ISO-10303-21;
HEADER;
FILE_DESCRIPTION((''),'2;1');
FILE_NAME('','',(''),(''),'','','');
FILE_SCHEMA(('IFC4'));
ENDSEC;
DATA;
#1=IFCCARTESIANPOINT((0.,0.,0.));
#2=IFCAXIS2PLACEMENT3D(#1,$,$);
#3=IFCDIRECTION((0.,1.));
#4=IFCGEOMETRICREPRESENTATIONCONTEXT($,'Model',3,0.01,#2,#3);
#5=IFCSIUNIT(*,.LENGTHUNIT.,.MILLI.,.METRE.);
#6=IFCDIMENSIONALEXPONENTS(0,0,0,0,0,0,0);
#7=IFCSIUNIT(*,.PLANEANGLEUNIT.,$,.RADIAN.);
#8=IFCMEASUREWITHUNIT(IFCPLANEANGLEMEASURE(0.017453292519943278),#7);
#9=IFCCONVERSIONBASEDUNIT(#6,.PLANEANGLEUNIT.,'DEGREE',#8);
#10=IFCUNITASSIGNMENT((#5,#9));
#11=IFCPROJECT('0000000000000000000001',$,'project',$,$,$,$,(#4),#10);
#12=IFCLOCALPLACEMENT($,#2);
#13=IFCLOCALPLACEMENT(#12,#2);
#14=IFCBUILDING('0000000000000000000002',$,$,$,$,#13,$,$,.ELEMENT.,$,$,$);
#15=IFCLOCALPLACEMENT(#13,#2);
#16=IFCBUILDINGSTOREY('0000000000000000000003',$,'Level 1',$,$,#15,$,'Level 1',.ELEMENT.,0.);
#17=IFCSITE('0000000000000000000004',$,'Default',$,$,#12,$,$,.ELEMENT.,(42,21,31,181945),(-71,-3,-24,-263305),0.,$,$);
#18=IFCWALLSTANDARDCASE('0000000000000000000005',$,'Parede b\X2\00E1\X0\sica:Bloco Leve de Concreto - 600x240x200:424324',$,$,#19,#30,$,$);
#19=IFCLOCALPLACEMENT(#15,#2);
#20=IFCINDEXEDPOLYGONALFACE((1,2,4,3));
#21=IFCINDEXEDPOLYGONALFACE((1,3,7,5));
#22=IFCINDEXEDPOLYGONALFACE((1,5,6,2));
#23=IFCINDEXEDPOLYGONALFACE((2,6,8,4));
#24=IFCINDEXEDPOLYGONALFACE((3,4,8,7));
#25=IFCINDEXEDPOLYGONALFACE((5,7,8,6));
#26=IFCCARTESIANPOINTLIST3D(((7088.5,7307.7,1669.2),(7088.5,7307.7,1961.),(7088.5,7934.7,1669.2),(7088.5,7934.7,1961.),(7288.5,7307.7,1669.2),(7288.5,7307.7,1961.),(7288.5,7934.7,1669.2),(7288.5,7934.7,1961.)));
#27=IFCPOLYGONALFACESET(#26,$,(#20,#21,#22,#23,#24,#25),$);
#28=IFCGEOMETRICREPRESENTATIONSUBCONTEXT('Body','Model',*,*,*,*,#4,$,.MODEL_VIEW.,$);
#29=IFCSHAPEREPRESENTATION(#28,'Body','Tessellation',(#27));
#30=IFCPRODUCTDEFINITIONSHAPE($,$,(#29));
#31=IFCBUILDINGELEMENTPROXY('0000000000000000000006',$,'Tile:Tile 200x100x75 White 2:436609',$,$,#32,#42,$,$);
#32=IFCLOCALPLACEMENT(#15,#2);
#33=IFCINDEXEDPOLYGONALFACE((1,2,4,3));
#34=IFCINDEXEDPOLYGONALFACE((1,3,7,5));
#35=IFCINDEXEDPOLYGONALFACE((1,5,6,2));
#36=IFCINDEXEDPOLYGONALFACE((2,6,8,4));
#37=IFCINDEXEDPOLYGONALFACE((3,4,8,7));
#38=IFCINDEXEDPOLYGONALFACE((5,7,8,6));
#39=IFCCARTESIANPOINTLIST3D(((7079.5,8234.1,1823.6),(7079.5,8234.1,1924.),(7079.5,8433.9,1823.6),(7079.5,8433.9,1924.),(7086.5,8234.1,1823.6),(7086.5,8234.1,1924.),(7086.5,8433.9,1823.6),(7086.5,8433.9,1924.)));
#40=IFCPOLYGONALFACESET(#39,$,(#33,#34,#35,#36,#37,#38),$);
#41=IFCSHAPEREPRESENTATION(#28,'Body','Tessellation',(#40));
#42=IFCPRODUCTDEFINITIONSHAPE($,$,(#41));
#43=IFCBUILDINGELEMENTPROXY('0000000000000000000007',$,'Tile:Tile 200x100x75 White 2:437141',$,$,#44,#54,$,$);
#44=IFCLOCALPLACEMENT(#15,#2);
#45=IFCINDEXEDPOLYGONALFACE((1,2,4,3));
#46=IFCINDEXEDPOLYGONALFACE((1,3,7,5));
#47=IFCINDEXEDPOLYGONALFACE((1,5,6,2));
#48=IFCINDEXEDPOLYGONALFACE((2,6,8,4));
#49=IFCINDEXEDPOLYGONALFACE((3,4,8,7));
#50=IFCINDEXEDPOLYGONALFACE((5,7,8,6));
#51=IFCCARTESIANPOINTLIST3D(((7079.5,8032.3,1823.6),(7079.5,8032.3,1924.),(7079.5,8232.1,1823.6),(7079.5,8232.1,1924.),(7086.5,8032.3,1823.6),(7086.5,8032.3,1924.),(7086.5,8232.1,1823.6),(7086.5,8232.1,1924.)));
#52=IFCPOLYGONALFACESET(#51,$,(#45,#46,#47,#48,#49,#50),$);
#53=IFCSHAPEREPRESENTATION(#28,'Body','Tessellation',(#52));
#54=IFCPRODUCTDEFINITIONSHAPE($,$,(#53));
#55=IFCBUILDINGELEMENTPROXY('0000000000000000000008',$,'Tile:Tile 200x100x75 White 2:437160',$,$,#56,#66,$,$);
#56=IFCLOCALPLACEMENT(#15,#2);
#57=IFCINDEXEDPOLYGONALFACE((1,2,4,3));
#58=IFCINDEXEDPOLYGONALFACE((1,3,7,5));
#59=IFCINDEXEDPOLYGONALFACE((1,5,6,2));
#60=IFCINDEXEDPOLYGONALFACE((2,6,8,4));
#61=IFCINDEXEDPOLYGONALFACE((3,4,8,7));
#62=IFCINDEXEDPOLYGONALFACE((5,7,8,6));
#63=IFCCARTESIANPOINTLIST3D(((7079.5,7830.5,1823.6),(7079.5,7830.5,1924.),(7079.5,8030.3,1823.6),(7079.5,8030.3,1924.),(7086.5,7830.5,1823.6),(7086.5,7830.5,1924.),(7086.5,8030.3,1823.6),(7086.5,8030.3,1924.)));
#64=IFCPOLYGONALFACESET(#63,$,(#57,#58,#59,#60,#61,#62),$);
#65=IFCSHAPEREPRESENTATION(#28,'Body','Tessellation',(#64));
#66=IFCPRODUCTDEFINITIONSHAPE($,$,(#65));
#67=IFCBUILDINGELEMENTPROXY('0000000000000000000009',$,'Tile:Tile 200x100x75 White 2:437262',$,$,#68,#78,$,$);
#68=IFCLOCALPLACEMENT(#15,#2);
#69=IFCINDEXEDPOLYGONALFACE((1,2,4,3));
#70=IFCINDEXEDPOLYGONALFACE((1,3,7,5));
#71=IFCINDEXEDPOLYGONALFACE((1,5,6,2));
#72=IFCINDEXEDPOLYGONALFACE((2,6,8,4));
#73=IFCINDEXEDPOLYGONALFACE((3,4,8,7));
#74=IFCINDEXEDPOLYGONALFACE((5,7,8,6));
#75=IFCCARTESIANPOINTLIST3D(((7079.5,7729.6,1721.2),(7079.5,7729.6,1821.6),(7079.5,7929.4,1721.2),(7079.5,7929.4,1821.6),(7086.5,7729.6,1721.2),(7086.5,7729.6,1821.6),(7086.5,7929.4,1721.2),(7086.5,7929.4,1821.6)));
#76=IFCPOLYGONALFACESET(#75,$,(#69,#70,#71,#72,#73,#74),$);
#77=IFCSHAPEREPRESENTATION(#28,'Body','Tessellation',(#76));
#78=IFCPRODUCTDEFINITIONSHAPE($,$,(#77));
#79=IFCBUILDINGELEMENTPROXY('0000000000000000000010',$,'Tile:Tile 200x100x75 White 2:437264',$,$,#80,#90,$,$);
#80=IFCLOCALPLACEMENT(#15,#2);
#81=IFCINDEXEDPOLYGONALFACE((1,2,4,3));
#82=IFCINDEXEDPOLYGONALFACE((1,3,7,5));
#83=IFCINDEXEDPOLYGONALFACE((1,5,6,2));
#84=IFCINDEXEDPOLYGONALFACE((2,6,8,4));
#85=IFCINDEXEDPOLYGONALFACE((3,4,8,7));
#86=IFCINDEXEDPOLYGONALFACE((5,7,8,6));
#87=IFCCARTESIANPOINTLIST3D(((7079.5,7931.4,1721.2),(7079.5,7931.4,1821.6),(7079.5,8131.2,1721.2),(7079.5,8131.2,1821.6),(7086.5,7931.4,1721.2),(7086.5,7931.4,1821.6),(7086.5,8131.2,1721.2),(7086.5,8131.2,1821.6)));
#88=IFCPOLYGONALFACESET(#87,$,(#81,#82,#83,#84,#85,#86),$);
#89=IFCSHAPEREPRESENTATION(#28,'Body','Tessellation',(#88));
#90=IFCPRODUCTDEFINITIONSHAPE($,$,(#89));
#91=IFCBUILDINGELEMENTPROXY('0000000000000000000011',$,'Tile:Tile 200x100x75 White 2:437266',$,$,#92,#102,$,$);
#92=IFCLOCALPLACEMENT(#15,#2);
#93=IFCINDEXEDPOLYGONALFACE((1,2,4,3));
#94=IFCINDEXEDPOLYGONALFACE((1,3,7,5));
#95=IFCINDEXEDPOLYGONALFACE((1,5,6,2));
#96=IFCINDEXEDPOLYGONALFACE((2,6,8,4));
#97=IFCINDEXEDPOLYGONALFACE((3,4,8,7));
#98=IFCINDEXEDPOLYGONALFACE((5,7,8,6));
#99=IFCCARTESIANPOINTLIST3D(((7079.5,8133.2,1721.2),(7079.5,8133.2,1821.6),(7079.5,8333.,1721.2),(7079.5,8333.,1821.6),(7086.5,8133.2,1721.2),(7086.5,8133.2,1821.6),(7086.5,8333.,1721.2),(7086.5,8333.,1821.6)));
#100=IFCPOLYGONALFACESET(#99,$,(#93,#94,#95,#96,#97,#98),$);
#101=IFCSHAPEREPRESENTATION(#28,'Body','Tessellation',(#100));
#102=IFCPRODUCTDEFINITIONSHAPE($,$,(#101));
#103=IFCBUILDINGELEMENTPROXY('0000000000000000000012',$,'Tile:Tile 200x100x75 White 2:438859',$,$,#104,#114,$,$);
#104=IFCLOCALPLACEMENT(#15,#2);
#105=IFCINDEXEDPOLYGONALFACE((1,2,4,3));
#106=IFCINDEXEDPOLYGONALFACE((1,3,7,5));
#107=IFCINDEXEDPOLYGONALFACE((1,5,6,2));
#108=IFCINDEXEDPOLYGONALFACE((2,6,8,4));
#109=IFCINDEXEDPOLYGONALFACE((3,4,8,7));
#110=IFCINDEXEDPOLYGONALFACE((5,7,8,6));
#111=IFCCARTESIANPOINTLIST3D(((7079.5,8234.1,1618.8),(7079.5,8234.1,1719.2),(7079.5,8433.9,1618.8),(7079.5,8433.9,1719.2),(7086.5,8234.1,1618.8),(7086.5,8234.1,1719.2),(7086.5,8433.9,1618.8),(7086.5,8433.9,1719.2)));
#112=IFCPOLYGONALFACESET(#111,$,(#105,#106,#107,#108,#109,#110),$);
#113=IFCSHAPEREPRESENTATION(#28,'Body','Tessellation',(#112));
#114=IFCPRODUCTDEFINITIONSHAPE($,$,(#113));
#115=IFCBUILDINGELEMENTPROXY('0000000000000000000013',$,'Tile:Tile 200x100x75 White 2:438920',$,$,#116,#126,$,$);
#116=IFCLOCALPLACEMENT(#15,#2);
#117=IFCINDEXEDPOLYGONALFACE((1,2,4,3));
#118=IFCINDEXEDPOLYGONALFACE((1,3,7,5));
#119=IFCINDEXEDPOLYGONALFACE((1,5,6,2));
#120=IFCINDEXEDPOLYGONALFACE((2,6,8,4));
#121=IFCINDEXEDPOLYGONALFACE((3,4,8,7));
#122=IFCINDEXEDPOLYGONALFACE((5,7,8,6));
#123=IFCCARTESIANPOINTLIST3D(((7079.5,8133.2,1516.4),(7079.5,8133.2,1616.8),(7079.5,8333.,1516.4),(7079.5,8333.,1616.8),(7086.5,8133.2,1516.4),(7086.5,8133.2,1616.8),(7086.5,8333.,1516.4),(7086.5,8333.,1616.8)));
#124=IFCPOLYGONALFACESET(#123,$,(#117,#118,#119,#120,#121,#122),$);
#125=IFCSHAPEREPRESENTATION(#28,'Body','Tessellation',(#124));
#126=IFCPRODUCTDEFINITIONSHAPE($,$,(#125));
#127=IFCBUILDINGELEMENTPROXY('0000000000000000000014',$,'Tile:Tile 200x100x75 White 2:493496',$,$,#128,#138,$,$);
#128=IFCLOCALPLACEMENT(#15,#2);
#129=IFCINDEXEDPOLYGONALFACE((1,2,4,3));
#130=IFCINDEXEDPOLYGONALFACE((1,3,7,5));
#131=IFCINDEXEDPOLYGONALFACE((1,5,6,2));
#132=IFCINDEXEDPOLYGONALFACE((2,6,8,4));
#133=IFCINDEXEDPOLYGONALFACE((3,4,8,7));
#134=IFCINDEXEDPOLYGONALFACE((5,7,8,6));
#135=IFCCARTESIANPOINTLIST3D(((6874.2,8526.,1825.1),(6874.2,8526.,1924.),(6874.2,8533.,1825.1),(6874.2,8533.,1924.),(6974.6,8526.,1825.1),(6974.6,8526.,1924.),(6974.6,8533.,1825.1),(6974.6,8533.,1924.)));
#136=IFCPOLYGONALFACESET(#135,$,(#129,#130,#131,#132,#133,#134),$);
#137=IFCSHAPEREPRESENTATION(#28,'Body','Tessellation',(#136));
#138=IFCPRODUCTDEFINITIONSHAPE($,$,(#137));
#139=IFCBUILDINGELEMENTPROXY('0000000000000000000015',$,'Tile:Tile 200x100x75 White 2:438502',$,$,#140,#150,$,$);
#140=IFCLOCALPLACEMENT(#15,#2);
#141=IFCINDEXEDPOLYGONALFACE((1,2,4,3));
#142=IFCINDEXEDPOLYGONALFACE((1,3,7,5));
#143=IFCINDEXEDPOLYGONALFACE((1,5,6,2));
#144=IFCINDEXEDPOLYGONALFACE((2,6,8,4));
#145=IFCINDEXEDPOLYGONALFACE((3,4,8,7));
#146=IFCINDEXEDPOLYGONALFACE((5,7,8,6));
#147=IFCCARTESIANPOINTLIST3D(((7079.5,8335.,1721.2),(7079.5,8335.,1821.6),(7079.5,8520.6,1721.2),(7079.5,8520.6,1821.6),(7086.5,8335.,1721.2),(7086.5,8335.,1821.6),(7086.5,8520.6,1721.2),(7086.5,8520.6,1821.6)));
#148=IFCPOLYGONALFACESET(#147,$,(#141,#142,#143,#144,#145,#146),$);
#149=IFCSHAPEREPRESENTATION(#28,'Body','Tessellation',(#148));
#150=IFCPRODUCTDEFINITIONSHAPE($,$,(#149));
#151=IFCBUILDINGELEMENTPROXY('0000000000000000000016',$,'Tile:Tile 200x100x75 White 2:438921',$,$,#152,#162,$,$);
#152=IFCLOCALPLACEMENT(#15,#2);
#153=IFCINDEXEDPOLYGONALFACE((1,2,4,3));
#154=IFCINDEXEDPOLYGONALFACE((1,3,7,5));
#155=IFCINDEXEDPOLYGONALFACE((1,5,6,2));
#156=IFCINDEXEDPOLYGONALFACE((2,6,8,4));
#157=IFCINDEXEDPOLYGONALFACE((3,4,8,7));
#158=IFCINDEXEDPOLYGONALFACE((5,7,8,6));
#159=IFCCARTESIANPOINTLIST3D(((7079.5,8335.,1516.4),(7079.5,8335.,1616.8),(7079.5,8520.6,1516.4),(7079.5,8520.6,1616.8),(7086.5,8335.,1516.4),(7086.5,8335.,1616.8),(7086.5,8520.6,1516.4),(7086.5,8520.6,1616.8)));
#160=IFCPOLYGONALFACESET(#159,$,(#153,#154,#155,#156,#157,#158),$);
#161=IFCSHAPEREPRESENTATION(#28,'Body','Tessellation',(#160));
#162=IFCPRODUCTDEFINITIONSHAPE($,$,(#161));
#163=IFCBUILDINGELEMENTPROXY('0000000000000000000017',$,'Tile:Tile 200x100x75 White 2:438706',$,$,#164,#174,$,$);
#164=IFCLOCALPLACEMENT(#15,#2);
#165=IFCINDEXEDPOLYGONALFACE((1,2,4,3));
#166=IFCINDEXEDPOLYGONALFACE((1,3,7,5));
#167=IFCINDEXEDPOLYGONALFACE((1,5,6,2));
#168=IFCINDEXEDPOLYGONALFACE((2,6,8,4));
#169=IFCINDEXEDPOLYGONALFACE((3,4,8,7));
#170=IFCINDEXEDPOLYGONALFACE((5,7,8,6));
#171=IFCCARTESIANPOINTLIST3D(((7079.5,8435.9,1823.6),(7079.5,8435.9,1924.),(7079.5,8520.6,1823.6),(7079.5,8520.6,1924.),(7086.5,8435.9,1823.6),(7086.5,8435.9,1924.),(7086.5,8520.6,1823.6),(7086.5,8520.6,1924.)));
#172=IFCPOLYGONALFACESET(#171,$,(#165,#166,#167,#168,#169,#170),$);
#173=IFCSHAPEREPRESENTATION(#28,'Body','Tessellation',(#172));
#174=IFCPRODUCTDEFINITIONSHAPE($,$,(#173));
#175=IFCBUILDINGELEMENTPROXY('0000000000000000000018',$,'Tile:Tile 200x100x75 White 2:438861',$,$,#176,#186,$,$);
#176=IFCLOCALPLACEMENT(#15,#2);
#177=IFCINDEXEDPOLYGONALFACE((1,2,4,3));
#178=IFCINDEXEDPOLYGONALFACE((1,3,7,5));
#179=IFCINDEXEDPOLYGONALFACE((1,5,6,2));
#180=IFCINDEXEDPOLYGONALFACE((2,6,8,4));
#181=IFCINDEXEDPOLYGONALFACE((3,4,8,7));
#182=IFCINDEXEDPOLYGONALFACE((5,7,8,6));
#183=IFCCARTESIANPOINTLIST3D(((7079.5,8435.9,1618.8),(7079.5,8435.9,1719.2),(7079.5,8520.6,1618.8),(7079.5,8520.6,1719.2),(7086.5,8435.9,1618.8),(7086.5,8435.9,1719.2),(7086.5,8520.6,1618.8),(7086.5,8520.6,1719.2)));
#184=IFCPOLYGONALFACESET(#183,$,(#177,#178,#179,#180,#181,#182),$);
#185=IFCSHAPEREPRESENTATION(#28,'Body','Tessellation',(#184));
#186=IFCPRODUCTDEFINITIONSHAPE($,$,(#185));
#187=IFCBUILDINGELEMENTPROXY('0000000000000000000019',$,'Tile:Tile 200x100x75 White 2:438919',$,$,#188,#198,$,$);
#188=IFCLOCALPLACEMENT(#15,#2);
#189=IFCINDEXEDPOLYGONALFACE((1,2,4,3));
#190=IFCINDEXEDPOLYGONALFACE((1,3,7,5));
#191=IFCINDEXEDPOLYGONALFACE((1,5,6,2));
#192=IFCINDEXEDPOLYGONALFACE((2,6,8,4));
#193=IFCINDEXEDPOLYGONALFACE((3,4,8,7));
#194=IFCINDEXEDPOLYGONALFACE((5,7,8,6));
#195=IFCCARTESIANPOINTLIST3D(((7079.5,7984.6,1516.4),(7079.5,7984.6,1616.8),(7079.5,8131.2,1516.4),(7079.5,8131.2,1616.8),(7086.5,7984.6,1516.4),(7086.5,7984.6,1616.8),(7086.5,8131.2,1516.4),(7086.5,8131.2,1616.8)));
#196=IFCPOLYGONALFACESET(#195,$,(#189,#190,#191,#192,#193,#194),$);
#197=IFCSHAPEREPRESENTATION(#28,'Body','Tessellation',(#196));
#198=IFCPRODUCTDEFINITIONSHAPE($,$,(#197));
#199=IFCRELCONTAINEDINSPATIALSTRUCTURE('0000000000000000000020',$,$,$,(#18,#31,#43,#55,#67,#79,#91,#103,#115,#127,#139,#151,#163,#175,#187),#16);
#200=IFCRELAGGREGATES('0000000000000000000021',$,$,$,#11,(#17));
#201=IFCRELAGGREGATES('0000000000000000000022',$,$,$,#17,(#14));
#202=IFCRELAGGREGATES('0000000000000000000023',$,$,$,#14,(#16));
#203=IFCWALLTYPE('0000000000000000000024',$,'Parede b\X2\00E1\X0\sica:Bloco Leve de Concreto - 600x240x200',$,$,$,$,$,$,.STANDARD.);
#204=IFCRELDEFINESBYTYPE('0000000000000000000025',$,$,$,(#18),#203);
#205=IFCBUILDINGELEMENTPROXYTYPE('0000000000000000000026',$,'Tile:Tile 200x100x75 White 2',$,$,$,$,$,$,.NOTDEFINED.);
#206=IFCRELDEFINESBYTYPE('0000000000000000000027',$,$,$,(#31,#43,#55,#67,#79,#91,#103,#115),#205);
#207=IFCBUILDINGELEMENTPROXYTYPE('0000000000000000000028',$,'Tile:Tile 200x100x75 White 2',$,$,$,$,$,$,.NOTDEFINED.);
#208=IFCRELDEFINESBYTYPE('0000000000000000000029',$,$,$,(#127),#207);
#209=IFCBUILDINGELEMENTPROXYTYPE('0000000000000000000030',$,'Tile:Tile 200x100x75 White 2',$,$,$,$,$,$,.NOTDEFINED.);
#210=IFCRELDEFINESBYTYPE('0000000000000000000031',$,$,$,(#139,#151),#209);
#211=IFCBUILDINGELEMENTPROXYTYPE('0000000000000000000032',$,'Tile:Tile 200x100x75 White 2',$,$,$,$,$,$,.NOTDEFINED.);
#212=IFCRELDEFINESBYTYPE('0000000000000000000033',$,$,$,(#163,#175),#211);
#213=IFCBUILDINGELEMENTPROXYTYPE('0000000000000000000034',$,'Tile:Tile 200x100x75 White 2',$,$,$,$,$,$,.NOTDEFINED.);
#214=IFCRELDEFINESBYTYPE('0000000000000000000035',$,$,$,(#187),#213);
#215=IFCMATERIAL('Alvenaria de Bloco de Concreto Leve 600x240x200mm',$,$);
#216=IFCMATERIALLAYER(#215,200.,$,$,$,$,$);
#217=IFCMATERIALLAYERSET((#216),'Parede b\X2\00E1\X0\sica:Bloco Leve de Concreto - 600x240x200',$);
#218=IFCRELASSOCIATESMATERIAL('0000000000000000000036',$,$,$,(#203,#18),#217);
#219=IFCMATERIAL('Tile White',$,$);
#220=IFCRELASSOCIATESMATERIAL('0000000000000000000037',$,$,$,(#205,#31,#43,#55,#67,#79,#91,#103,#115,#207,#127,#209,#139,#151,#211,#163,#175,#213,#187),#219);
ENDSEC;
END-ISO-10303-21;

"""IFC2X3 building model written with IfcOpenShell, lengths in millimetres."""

from ifc_helpers import new_model, entity, si_unit, converted_unit, direction, frame, frame_2d, origin, origin_2d_with_axis, place, context, subcontext, project, spatial, rectangle, extrude, source, transform, mapped, material, layer, layer_set, layer_usage, type_object, type_shapes, element, save


model = new_model("IFC2X3")

# Units and contexts
model_context = context("Model", 3, precision=0.01, world=origin(), true_north=direction((0.0, 1.0)))
body_context = subcontext(model_context, "Body", "Model", "MODEL_VIEW")
ifc_project = project(units=[si_unit("LENGTHUNIT", "METRE", prefix="MILLI"), converted_unit("PLANEANGLEUNIT", "DEGREE", entity("IfcPlaneAngleMeasure", 0.017453292519943278), si_unit("PLANEANGLEUNIT", "RADIAN"), dimensions=[0, 0, 0, 0, 0, 0, 0])], contexts=[model_context])

# Site, building, storey
site_placement = place(None, origin())
site = spatial("IfcSite", under=ifc_project, at=site_placement, Name="Default", CompositionType="ELEMENT", RefLatitude=(42, 21, 31, 181945), RefLongitude=(-71, -3, -24, -263305), RefElevation=0.0)
building_placement = place(site_placement, origin())
building = spatial("IfcBuilding", under=site, at=building_placement, CompositionType="ELEMENT")
storey_placement = place(building_placement, origin())
storey = spatial("IfcBuildingStorey", under=building, at=storey_placement, Name="Level 1", LongName="Level 1", CompositionType="ELEMENT", Elevation=0.0)

# Wall
ifc_material_1 = material(Name="Alvenaria de Bloco de Concreto Leve 600x240x200mm")
ifc_layer = layer(ifc_material_1, 200.0)
ifc_layer_set = layer_set([ifc_layer], Name="Parede básica:Bloco Leve de Concreto - 600x240x200")
ifc_layer_usage = layer_usage(ifc_layer_set, "AXIS2", "NEGATIVE", 100.0)
wall_type = type_object("IfcWallType", Name="Parede básica:Bloco Leve de Concreto - 600x240x200", PredefinedType="STANDARD", material=ifc_layer_set)
wall_placement = place(storey_placement, frame((7188.5, 7934.7, 1669.2), z_axis=(0.0, 0.0, 1.0), x_axis=(0.0, -1.0, 0.0)))
element("IfcWallStandardCase", 1, at=wall_placement, inside=storey, type_object=wall_type, material=ifc_layer_usage, Name="Parede básica:Bloco Leve de Concreto - 600x240x200:424324", context=body_context, shape_type="SweptSolid", body=[
    extrude(rectangle(XDim=627.0, YDim=200.0, at=frame_2d((313.5, 0.0), x_axis=(-1.0, 0.0))), origin(), (0.0, 0.0, 1.0), 291.8),
])

# Building element proxies
ifc_material_2 = material(Name="Tile White")
building_element_proxy_type_1 = type_object("IfcBuildingElementProxyType", Name="Tile:Tile 200x100x75 White 2", PredefinedType="NOTDEFINED", material=ifc_material_2)
shared_shape_1 = source(origin(), body_context, "Body", "SweptSolid", [
    extrude(rectangle(XDim=199.8, YDim=100.4, at=frame_2d((0.0, 0.0), x_axis=(1.0, 0.0))), frame((-50.2, -99.9, 0.0), z_axis=(0.0, 0.0, 1.0), x_axis=(0.0, -1.0, 0.0)), (0.0, 0.0, 1.0), 7.0),
])
type_shapes(building_element_proxy_type_1, [shared_shape_1])
for number, where, z_axis, x_axis, name in (
    (2, (7086.5, 8433.9, 1924.0), (-1.0, 0.0, 0.0), (0.0, 0.0, 1.0), "Tile:Tile 200x100x75 White 2:436609"),
    (3, (7086.5, 8232.1, 1924.0), (-1.0, 0.0, 0.0), (0.0, 0.0, 1.0), "Tile:Tile 200x100x75 White 2:437141"),
    (4, (7086.5, 8030.3, 1924.0), (-1.0, 0.0, 0.0), (0.0, 0.0, 1.0), "Tile:Tile 200x100x75 White 2:437160"),
    (5, (7086.5, 7929.4, 1821.6), (-1.0, 0.0, 0.0), (0.0, 0.0, 1.0), "Tile:Tile 200x100x75 White 2:437262"),
    (6, (7086.5, 8131.2, 1821.6), (-1.0, 0.0, 0.0), (0.0, 0.0, 1.0), "Tile:Tile 200x100x75 White 2:437264"),
    (7, (7086.5, 8333.0, 1821.6), (-1.0, 0.0, 0.0), (0.0, 0.0, 1.0), "Tile:Tile 200x100x75 White 2:437266"),
    (8, (7086.5, 8433.9, 1719.2), (-1.0, 0.0, 0.0), (0.0, 0.0, 1.0), "Tile:Tile 200x100x75 White 2:438859"),
    (9, (7086.5, 8333.0, 1616.8), (-1.0, 0.0, 0.0), (0.0, 0.0, 1.0), "Tile:Tile 200x100x75 White 2:438920"),
):
    element("IfcBuildingElementProxy", number, at=place(storey_placement, frame(where, z_axis=z_axis, x_axis=x_axis)), inside=storey, type_object=building_element_proxy_type_1, material=ifc_material_2, Name=name, context=body_context, shape_type="MappedRepresentation", body=[
        mapped(shared_shape_1, transform((0.0, 0.0, 0.0), scale=1.0)),
    ])
building_element_proxy_type_2 = type_object("IfcBuildingElementProxyType", Name="Tile:Tile 200x100x75 White 2", PredefinedType="NOTDEFINED", material=ifc_material_2)
shared_shape_2 = source(origin(), body_context, "Body", "SweptSolid", [
    extrude(rectangle(XDim=98.9, YDim=100.4, at=origin_2d_with_axis()), frame((-50.2, -49.5, 0.0), z_axis=(0.0, 0.0, 1.0), x_axis=(0.0, -1.0, 0.0)), (0.0, 0.0, 1.0), 7.0),
])
type_shapes(building_element_proxy_type_2, [shared_shape_2])
proxy_1_placement = place(storey_placement, frame((6974.6, 8533.0, 1924.0), z_axis=(0.0, -1.0, 0.0), x_axis=(1.0, 0.0, 0.0)))
element("IfcBuildingElementProxy", 10, at=proxy_1_placement, inside=storey, type_object=building_element_proxy_type_2, material=ifc_material_2, Name="Tile:Tile 200x100x75 White 2:493496", context=body_context, shape_type="MappedRepresentation", body=[
    mapped(shared_shape_2, transform((0.0, 0.0, 0.0), scale=1.0)),
])
building_element_proxy_type_3 = type_object("IfcBuildingElementProxyType", Name="Tile:Tile 200x100x75 White 2", PredefinedType="NOTDEFINED", material=ifc_material_2)
shared_shape_3 = source(origin(), body_context, "Body", "SweptSolid", [
    extrude(rectangle(XDim=185.6, YDim=100.4, at=frame_2d((0.0, 0.0), x_axis=(1.0, 0.0))), frame((-50.2, -92.8, 0.0), z_axis=(0.0, 0.0, 1.0), x_axis=(0.0, -1.0, 0.0)), (0.0, 0.0, 1.0), 7.0),
])
type_shapes(building_element_proxy_type_3, [shared_shape_3])
for number, where, z_axis, x_axis, name in (
    (11, (7086.5, 8520.6, 1821.6), (-1.0, 0.0, 0.0), (0.0, 0.0, 1.0), "Tile:Tile 200x100x75 White 2:438502"),
    (12, (7086.5, 8520.6, 1616.8), (-1.0, 0.0, 0.0), (0.0, 0.0, 1.0), "Tile:Tile 200x100x75 White 2:438921"),
):
    element("IfcBuildingElementProxy", number, at=place(storey_placement, frame(where, z_axis=z_axis, x_axis=x_axis)), inside=storey, type_object=building_element_proxy_type_3, material=ifc_material_2, Name=name, context=body_context, shape_type="MappedRepresentation", body=[
        mapped(shared_shape_3, transform((0.0, 0.0, 0.0), scale=1.0)),
    ])
building_element_proxy_type_4 = type_object("IfcBuildingElementProxyType", Name="Tile:Tile 200x100x75 White 2", PredefinedType="NOTDEFINED", material=ifc_material_2)
shared_shape_4 = source(origin(), body_context, "Body", "SweptSolid", [
    extrude(rectangle(XDim=84.7, YDim=100.4, at=frame_2d((0.0, 0.0), x_axis=(1.0, 0.0))), frame((-50.2, -42.4, 0.0), z_axis=(0.0, 0.0, 1.0), x_axis=(0.0, -1.0, 0.0)), (0.0, 0.0, 1.0), 7.0),
])
type_shapes(building_element_proxy_type_4, [shared_shape_4])
for number, where, z_axis, x_axis, name in (
    (13, (7086.5, 8520.6, 1924.0), (-1.0, 0.0, 0.0), (0.0, 0.0, 1.0), "Tile:Tile 200x100x75 White 2:438706"),
    (14, (7086.5, 8520.6, 1719.2), (-1.0, 0.0, 0.0), (0.0, 0.0, 1.0), "Tile:Tile 200x100x75 White 2:438861"),
):
    element("IfcBuildingElementProxy", number, at=place(storey_placement, frame(where, z_axis=z_axis, x_axis=x_axis)), inside=storey, type_object=building_element_proxy_type_4, material=ifc_material_2, Name=name, context=body_context, shape_type="MappedRepresentation", body=[
        mapped(shared_shape_4, transform((0.0, 0.0, 0.0), scale=1.0)),
    ])
building_element_proxy_type_5 = type_object("IfcBuildingElementProxyType", Name="Tile:Tile 200x100x75 White 2", PredefinedType="NOTDEFINED", material=ifc_material_2)
shared_shape_5 = source(origin(), body_context, "Body", "SweptSolid", [
    extrude(rectangle(XDim=146.6, YDim=100.4, at=origin_2d_with_axis()), frame((-50.2, -73.3, 0.0), z_axis=(0.0, 0.0, 1.0), x_axis=(0.0, -1.0, 0.0)), (0.0, 0.0, 1.0), 7.0),
])
type_shapes(building_element_proxy_type_5, [shared_shape_5])
proxy_2_placement = place(storey_placement, frame((7086.5, 8131.2, 1616.8), z_axis=(-1.0, 0.0, 0.0), x_axis=(0.0, 0.0, 1.0)))
element("IfcBuildingElementProxy", 15, at=proxy_2_placement, inside=storey, type_object=building_element_proxy_type_5, material=ifc_material_2, Name="Tile:Tile 200x100x75 White 2:438919", context=body_context, shape_type="MappedRepresentation", body=[
    mapped(shared_shape_5, transform((0.0, 0.0, 0.0), scale=1.0)),
])

save(model, "model.ifc")
